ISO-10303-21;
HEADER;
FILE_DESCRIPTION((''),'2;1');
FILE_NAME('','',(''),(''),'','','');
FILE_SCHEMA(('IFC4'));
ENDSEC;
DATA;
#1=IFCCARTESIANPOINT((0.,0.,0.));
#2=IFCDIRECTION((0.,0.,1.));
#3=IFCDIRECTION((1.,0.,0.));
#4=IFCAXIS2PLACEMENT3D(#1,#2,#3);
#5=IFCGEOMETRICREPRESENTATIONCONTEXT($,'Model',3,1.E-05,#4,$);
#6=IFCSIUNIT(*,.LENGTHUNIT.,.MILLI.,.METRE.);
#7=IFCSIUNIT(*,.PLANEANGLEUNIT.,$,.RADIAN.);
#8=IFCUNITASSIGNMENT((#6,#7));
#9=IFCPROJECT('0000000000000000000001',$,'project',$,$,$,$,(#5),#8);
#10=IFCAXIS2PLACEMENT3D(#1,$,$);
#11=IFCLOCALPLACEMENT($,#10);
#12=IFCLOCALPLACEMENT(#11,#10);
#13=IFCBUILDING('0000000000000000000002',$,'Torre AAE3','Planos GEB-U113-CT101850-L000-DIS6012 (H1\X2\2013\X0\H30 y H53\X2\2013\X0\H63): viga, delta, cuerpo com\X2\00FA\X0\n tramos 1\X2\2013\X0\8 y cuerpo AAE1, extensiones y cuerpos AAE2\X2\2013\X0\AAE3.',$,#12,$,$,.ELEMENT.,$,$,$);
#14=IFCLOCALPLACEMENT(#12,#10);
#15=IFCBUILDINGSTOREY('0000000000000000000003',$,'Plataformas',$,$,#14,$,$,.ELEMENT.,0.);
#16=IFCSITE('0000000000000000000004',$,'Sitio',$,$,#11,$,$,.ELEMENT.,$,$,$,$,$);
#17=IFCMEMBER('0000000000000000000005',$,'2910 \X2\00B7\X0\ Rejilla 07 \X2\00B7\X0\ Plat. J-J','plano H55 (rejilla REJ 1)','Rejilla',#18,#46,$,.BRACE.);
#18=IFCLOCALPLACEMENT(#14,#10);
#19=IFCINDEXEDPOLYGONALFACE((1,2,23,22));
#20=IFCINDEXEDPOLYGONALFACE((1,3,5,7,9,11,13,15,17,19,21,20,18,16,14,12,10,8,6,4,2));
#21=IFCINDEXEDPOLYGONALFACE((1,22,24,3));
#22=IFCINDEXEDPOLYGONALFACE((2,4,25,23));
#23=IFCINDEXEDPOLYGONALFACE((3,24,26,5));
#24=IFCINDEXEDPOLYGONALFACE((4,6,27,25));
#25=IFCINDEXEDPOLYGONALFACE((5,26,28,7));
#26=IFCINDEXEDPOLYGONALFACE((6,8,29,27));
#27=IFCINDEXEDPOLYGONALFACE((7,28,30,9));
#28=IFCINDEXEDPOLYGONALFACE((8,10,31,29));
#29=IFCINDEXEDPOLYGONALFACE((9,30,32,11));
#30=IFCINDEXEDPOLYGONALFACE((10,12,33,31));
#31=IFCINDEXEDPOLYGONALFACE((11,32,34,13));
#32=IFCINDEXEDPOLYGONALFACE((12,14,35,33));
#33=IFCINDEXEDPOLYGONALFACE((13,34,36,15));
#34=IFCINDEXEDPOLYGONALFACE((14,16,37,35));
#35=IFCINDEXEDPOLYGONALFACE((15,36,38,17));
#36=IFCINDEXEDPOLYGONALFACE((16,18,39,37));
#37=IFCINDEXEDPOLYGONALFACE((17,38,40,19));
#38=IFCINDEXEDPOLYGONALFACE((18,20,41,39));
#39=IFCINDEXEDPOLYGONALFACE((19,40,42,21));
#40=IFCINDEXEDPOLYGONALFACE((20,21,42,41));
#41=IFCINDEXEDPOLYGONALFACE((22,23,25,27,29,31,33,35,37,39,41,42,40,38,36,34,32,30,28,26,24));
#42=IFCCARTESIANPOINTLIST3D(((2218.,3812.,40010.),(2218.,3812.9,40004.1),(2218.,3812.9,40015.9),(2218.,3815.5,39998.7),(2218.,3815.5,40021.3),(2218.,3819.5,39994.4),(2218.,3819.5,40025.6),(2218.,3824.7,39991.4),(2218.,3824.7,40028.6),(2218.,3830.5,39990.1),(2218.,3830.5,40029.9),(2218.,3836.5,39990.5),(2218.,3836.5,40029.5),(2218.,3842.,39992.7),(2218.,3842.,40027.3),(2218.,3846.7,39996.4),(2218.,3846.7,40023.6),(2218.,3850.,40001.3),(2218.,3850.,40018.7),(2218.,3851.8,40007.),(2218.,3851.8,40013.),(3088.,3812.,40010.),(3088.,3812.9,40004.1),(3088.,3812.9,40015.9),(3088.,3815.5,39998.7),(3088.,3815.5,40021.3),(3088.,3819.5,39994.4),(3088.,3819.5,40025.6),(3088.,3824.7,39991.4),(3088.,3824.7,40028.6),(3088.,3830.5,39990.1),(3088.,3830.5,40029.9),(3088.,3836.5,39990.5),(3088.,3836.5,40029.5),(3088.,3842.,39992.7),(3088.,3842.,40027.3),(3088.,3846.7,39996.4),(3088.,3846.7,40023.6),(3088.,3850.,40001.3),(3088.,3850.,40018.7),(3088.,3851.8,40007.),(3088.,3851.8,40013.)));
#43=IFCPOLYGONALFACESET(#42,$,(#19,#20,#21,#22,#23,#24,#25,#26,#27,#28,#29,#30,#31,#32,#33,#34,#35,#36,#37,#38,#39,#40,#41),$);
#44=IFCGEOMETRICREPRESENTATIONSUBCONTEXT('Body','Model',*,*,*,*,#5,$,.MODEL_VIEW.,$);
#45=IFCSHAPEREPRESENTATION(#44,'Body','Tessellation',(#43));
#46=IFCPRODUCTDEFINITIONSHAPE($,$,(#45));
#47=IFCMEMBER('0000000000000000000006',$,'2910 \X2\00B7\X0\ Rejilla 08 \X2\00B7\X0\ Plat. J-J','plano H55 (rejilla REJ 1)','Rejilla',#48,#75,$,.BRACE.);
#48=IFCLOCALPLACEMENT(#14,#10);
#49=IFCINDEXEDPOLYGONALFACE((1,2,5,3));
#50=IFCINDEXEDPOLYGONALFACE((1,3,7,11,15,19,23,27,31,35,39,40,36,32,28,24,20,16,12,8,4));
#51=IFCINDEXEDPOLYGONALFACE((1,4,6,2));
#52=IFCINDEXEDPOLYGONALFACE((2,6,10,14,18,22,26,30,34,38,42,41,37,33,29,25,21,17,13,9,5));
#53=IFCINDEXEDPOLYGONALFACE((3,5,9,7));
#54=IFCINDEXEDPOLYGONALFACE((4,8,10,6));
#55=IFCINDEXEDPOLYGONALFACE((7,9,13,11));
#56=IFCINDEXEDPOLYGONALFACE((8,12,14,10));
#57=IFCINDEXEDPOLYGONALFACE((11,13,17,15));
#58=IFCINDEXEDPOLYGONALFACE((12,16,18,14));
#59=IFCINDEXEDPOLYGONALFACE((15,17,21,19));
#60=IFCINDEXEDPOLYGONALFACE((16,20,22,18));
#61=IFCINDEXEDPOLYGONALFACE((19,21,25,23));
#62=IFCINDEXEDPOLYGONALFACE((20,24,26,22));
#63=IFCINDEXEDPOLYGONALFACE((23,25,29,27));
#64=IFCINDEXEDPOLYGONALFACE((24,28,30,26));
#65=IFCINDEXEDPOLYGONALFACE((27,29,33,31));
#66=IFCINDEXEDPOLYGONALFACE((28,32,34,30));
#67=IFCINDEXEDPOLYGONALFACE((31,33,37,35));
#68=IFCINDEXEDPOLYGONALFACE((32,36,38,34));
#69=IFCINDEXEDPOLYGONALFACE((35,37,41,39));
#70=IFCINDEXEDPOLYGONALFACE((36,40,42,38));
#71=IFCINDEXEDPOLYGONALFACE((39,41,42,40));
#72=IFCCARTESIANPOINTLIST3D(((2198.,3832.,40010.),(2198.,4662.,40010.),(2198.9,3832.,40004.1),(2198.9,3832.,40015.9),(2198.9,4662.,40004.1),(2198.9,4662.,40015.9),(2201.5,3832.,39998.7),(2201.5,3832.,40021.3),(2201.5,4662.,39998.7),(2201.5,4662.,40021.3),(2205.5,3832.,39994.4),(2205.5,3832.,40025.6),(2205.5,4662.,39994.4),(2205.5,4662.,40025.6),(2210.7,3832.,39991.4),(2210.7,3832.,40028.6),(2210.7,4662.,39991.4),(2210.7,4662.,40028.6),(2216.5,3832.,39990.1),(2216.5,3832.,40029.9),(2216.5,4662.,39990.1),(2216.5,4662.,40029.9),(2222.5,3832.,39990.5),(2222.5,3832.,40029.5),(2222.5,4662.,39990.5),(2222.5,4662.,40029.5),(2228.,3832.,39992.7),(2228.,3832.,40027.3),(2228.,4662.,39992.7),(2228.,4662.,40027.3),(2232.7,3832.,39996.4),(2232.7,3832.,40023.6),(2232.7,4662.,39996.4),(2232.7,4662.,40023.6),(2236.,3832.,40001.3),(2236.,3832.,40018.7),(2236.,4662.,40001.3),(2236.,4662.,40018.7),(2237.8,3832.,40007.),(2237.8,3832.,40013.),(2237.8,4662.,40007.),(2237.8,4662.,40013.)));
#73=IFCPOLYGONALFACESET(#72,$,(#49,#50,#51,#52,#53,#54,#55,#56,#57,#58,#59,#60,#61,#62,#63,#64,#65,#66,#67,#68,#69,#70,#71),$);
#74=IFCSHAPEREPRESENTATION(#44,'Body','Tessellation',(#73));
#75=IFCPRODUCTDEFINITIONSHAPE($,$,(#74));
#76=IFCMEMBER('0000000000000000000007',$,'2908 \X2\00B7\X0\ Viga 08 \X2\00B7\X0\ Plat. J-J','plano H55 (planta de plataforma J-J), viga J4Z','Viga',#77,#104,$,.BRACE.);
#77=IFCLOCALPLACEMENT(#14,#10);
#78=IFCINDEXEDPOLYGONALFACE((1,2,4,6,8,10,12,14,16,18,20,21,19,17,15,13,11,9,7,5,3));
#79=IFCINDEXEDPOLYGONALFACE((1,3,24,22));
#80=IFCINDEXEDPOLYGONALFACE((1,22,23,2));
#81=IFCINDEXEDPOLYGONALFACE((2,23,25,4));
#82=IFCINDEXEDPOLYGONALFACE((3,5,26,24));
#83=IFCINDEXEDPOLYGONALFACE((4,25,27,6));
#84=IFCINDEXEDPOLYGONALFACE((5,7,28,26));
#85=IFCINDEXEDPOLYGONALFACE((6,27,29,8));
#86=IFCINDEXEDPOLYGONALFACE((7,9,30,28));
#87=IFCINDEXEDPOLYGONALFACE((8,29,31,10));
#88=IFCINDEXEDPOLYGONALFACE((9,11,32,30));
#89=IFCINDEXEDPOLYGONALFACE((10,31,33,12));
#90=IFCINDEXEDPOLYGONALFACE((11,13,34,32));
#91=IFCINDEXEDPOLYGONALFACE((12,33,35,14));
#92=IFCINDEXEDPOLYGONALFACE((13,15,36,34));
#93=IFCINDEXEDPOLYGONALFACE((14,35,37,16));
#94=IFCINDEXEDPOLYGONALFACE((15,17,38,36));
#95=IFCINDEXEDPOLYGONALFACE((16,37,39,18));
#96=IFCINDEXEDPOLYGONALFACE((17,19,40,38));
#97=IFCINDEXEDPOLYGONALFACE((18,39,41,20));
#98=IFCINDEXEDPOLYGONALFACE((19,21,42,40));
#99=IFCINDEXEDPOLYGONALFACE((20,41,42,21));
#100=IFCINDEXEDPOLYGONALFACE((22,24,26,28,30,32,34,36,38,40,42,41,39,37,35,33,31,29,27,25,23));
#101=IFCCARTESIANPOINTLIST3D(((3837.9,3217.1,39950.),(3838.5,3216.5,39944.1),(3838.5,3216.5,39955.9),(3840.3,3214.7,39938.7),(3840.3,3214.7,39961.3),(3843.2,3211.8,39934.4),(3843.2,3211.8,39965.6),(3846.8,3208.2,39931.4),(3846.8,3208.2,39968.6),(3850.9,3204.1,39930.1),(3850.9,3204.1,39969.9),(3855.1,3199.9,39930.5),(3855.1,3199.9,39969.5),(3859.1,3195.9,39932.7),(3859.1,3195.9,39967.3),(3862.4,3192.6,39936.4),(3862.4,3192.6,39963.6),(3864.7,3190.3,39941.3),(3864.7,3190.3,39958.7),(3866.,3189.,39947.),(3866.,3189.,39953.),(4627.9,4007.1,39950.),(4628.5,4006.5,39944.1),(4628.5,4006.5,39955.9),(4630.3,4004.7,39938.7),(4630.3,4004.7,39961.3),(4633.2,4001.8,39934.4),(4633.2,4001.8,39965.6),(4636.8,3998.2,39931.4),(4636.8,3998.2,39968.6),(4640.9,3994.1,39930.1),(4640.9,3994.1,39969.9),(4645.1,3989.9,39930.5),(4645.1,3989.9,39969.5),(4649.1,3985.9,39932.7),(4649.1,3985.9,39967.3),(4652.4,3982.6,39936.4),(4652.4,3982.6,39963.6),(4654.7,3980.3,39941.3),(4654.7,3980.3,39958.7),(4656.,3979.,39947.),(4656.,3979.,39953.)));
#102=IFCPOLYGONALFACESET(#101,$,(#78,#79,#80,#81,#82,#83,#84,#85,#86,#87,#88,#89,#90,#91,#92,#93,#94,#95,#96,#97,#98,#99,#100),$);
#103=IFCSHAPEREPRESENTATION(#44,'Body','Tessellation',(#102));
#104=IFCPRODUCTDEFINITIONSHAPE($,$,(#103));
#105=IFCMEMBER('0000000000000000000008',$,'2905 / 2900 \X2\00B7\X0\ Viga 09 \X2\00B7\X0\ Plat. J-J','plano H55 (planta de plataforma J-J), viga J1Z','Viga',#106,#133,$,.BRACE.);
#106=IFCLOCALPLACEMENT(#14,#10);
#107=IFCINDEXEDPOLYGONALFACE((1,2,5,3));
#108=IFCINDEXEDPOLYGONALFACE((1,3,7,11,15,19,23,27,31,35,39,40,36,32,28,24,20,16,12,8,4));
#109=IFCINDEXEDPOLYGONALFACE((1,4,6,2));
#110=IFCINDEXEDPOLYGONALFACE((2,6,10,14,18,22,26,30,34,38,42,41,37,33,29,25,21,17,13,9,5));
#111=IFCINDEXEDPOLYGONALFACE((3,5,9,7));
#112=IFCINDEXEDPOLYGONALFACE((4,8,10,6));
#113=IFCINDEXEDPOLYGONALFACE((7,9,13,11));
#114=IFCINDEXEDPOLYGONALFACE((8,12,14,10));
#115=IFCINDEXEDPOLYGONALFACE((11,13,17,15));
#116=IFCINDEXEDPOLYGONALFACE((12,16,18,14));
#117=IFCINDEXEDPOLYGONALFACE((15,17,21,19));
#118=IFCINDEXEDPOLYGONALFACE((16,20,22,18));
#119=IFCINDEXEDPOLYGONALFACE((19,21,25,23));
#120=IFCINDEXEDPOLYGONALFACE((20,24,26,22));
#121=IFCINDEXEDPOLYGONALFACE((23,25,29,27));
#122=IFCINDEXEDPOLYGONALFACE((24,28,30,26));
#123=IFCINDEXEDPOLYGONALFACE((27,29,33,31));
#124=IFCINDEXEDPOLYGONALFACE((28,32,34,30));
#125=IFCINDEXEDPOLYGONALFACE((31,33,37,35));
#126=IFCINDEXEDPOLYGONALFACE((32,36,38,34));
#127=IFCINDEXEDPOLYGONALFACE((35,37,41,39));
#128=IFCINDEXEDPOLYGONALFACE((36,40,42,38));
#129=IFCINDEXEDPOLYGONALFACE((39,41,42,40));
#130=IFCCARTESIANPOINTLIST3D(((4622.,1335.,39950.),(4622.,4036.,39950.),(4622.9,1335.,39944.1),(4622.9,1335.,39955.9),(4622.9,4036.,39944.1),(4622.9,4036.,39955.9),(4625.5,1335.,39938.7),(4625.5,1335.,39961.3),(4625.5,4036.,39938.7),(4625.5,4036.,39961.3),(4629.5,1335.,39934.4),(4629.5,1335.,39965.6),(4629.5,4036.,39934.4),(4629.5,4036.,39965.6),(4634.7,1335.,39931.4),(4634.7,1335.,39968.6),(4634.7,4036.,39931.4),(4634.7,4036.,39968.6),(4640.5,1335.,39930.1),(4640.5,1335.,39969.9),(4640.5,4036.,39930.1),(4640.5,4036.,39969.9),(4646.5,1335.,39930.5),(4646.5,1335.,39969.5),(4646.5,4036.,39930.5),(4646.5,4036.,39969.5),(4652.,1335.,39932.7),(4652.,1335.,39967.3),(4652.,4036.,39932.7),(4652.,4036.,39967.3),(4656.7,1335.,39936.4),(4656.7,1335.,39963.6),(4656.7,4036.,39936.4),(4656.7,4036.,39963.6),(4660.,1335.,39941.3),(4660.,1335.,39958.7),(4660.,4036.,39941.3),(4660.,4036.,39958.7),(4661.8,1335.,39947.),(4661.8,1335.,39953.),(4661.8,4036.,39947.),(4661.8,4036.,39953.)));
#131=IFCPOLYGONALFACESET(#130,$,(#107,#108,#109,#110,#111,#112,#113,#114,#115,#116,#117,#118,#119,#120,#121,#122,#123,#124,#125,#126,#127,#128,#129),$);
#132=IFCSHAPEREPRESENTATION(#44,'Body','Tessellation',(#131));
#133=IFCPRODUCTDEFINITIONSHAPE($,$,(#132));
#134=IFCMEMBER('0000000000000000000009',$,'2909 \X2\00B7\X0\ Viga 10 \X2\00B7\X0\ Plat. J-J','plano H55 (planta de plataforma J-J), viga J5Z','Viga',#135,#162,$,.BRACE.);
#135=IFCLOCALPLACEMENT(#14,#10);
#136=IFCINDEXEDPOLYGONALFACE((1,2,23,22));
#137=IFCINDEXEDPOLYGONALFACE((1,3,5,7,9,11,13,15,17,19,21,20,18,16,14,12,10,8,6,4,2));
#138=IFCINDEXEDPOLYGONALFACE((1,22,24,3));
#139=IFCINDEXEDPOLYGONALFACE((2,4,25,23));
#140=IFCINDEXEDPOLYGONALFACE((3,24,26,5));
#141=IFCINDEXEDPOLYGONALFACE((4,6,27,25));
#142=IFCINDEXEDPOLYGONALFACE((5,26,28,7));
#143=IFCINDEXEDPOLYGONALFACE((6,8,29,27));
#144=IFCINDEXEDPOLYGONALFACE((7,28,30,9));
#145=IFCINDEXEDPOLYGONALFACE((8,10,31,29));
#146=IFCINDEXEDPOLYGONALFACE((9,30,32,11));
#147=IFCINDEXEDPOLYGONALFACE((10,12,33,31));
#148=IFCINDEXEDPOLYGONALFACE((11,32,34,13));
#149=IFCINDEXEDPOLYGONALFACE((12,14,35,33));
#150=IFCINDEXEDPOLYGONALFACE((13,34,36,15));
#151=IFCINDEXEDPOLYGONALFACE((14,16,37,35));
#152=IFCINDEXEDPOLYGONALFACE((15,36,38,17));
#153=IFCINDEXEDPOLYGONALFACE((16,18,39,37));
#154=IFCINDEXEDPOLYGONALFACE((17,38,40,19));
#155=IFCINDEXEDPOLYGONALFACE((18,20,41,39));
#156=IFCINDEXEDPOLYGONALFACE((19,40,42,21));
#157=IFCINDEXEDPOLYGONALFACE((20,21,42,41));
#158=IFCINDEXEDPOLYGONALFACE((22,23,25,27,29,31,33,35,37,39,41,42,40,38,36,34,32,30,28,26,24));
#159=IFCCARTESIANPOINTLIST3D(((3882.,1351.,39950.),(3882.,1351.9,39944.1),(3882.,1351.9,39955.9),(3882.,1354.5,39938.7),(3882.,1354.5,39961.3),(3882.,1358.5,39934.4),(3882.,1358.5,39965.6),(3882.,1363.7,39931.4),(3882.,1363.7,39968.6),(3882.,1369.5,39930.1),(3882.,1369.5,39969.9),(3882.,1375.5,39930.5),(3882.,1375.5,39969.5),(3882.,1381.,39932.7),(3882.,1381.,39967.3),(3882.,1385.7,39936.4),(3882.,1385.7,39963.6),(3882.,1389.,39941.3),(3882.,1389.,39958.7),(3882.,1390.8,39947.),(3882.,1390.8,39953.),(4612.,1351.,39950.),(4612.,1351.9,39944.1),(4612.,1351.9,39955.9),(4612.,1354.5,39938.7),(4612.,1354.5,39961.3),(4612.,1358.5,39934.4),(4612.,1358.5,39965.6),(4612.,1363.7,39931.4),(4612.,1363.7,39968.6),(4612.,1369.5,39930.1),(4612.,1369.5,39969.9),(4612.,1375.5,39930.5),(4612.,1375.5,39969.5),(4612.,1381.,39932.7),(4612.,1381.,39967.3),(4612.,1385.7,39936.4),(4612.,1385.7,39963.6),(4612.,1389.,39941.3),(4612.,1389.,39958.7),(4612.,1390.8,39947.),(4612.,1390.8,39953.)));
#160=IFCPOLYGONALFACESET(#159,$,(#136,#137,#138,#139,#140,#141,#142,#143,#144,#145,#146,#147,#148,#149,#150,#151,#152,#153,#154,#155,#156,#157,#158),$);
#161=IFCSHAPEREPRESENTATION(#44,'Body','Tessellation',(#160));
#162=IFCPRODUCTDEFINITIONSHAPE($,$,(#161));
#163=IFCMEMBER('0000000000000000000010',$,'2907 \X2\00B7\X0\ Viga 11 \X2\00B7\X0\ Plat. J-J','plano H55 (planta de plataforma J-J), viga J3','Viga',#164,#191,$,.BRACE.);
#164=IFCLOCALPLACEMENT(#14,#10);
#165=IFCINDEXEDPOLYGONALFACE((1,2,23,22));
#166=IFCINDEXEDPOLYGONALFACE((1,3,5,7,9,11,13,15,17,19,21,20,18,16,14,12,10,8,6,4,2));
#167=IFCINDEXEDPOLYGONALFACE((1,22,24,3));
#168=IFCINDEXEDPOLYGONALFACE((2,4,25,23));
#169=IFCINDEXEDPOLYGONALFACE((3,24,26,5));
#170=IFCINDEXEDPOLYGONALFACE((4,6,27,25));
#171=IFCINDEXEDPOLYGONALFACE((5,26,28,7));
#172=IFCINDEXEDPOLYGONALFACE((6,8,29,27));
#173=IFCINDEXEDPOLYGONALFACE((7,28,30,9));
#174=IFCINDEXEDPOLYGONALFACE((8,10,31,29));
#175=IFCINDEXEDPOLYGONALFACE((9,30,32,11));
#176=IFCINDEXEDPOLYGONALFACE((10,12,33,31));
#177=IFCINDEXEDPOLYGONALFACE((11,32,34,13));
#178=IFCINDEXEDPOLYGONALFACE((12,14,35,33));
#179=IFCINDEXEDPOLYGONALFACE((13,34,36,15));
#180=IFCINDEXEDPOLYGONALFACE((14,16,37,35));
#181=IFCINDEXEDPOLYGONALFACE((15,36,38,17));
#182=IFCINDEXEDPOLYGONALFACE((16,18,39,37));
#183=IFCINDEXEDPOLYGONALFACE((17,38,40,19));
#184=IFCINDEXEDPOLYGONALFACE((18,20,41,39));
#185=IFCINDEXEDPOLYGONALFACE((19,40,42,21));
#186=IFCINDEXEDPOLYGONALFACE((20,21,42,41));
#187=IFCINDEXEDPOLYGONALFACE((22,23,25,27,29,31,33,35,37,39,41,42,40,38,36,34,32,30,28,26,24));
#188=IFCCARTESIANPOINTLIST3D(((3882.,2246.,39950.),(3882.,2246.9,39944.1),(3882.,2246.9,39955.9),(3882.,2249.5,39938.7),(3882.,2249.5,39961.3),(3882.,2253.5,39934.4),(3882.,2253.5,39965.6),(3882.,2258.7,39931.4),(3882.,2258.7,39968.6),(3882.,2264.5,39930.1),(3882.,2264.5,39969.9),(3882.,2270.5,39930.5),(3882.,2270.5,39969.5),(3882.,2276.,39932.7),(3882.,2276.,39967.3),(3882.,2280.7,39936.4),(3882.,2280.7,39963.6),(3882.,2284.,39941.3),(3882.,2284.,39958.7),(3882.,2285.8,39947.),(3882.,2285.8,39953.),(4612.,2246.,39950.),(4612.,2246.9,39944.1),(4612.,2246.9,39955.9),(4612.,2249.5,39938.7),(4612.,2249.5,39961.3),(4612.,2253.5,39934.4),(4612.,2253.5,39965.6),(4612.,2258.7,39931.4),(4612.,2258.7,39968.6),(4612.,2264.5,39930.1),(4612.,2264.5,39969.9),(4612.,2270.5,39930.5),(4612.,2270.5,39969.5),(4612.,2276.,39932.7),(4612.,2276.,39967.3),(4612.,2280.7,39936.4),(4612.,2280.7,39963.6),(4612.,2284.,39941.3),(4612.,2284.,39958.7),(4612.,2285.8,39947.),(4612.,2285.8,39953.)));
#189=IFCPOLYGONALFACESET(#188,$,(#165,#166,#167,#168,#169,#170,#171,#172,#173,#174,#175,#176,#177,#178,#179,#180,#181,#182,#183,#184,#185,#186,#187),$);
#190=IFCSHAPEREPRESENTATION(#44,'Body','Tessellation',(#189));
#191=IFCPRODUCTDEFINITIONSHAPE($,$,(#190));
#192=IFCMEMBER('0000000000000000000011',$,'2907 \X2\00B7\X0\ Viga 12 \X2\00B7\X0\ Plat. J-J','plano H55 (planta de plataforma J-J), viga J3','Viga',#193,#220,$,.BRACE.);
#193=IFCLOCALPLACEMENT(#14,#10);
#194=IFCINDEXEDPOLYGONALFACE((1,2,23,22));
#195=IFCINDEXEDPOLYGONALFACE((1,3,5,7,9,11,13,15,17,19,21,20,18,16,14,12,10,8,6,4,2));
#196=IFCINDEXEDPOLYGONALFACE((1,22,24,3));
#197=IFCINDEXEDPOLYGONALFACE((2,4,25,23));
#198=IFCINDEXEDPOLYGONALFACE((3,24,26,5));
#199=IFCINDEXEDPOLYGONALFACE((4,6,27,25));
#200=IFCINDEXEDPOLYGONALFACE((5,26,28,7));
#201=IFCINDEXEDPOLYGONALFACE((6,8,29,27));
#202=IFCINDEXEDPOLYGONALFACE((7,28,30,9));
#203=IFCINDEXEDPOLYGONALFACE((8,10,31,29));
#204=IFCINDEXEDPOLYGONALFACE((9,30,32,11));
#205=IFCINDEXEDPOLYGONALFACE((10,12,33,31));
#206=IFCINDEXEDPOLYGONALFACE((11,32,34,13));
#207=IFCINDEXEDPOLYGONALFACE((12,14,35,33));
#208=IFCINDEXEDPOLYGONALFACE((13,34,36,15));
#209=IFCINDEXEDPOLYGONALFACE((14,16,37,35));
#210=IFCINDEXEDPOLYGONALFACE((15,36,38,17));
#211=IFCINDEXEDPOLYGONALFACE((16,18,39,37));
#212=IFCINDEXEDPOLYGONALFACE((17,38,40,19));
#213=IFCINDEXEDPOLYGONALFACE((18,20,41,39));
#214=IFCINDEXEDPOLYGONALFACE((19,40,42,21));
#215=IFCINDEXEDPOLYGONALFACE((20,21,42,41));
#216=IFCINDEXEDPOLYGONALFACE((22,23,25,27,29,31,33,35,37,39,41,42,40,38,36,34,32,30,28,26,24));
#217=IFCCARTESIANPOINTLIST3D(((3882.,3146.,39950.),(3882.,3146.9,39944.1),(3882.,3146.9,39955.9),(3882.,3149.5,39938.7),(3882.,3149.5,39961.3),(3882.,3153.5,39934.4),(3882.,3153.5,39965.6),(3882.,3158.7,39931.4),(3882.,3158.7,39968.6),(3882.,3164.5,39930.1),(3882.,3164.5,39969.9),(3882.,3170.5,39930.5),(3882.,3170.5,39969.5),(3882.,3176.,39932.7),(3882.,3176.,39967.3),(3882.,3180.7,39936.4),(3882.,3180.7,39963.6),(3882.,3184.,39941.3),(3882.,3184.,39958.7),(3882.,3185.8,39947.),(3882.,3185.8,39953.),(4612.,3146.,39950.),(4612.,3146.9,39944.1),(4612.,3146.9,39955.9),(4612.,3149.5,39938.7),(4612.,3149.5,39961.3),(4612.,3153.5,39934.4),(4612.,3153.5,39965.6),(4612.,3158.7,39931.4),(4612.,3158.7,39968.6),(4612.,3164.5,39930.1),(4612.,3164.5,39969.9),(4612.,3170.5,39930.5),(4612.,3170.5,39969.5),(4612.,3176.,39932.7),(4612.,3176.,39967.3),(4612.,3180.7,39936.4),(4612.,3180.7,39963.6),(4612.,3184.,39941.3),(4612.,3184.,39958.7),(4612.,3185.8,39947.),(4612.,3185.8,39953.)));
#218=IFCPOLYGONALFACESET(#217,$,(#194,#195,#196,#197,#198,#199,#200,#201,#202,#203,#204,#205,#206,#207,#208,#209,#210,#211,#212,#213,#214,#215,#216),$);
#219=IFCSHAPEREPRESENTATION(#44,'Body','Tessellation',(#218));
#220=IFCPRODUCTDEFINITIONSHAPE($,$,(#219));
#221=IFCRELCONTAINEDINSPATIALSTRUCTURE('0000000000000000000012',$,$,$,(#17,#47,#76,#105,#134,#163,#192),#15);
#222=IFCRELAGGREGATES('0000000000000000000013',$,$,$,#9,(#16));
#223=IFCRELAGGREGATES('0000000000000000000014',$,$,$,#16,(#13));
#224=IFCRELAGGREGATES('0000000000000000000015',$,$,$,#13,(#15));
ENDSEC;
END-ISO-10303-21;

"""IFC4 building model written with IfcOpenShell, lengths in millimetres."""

from ifc_helpers import new_model, si_unit, frame, origin, origin_with_axes, place, context, subcontext, project, spatial, circle, extrude, element, save


model = new_model("IFC4")

# Units and contexts
model_context = context("Model", 3, precision=1e-05, world=origin_with_axes())
body_context = subcontext(model_context, "Body", "Model", "MODEL_VIEW")
ifc_project = project(units=[si_unit("LENGTHUNIT", "METRE", prefix="MILLI"), si_unit("PLANEANGLEUNIT", "RADIAN")], contexts=[model_context])

# Site, building, storey
site_placement = place(None, origin())
site = spatial("IfcSite", under=ifc_project, at=site_placement, Name="Sitio", CompositionType="ELEMENT")
building_placement = place(site_placement, origin())
building = spatial("IfcBuilding", under=site, at=building_placement, Name="Torre AAE3", Description="Planos GEB-U113-CT101850-L000-DIS6012 (H1–H30 y H53–H63): viga, delta, cuerpo común tramos 1–8 y cuerpo AAE1, extensiones y cuerpos AAE2–AAE3.", CompositionType="ELEMENT")
storey_placement = place(building_placement, origin())
storey = spatial("IfcBuildingStorey", under=building, at=storey_placement, Name="Plataformas", CompositionType="ELEMENT", Elevation=0.0)

# Members
member_1_placement = place(storey_placement, frame((3088.0, 3832.0, 40010.0), z_axis=(-1.0, 0.0, 0.0), x_axis=(0.0, -1.0, 0.0)))
element("IfcMember", 1, at=member_1_placement, inside=storey, Name="2910 · Rejilla 07 · Plat. J-J", Description="plano H55 (rejilla REJ 1)", ObjectType="Rejilla", PredefinedType="BRACE", context=body_context, shape_type="SweptSolid", body=[
    extrude(circle(Radius=20.0), None, (0.0, 0.0, 1.0), 870.0),
])
member_2_placement = place(storey_placement, frame((2218.0, 3832.0, 40010.0), z_axis=(0.0, 1.0, 0.0), x_axis=(-1.0, 0.0, 0.0)))
element("IfcMember", 2, at=member_2_placement, inside=storey, Name="2910 · Rejilla 08 · Plat. J-J", Description="plano H55 (rejilla REJ 1)", ObjectType="Rejilla", PredefinedType="BRACE", context=body_context, shape_type="SweptSolid", body=[
    extrude(circle(Radius=20.0), None, (0.0, 0.0, 1.0), 830.0),
])
member_3_placement = place(storey_placement, frame((4642.0, 3993.0, 39950.0), z_axis=(-0.707107, -0.707107, 0.0), x_axis=(-0.707107, 0.707107, 0.0)))
element("IfcMember", 3, at=member_3_placement, inside=storey, Name="2908 · Viga 08 · Plat. J-J", Description="plano H55 (planta de plataforma J-J), viga J4Z", ObjectType="Viga", PredefinedType="BRACE", context=body_context, shape_type="SweptSolid", body=[
    extrude(circle(Radius=20.0), None, (0.0, 0.0, 1.0), 1117.2),
])
member_4_placement = place(storey_placement, frame((4642.0, 4036.0, 39950.0), z_axis=(0.0, -1.0, 0.0), x_axis=(-1.0, 0.0, 0.0)))
element("IfcMember", 4, at=member_4_placement, inside=storey, Name="2905 / 2900 · Viga 09 · Plat. J-J", Description="plano H55 (planta de plataforma J-J), viga J1Z", ObjectType="Viga", PredefinedType="BRACE", context=body_context, shape_type="SweptSolid", body=[
    extrude(circle(Radius=20.0), None, (0.0, 0.0, 1.0), 2701.0),
])
for number, where, z_axis, x_axis, name, description in (
    (5, (4612.0, 1371.0, 39950.0), (-1.0, 0.0, 0.0), (0.0, -1.0, 0.0), "2909 · Viga 10 · Plat. J-J", "plano H55 (planta de plataforma J-J), viga J5Z"),
    (6, (4612.0, 2266.0, 39950.0), (-1.0, 0.0, 0.0), (0.0, -1.0, 0.0), "2907 · Viga 11 · Plat. J-J", "plano H55 (planta de plataforma J-J), viga J3"),
    (7, (4612.0, 3166.0, 39950.0), (-1.0, 0.0, 0.0), (0.0, -1.0, 0.0), "2907 · Viga 12 · Plat. J-J", "plano H55 (planta de plataforma J-J), viga J3"),
):
    element("IfcMember", number, at=place(storey_placement, frame(where, z_axis=z_axis, x_axis=x_axis)), inside=storey, Name=name, Description=description, ObjectType="Viga", PredefinedType="BRACE", context=body_context, shape_type="SweptSolid", body=[
        extrude(circle(Radius=20.0), None, (0.0, 0.0, 1.0), 730.0),
    ])

save(model, "model.ifc")
